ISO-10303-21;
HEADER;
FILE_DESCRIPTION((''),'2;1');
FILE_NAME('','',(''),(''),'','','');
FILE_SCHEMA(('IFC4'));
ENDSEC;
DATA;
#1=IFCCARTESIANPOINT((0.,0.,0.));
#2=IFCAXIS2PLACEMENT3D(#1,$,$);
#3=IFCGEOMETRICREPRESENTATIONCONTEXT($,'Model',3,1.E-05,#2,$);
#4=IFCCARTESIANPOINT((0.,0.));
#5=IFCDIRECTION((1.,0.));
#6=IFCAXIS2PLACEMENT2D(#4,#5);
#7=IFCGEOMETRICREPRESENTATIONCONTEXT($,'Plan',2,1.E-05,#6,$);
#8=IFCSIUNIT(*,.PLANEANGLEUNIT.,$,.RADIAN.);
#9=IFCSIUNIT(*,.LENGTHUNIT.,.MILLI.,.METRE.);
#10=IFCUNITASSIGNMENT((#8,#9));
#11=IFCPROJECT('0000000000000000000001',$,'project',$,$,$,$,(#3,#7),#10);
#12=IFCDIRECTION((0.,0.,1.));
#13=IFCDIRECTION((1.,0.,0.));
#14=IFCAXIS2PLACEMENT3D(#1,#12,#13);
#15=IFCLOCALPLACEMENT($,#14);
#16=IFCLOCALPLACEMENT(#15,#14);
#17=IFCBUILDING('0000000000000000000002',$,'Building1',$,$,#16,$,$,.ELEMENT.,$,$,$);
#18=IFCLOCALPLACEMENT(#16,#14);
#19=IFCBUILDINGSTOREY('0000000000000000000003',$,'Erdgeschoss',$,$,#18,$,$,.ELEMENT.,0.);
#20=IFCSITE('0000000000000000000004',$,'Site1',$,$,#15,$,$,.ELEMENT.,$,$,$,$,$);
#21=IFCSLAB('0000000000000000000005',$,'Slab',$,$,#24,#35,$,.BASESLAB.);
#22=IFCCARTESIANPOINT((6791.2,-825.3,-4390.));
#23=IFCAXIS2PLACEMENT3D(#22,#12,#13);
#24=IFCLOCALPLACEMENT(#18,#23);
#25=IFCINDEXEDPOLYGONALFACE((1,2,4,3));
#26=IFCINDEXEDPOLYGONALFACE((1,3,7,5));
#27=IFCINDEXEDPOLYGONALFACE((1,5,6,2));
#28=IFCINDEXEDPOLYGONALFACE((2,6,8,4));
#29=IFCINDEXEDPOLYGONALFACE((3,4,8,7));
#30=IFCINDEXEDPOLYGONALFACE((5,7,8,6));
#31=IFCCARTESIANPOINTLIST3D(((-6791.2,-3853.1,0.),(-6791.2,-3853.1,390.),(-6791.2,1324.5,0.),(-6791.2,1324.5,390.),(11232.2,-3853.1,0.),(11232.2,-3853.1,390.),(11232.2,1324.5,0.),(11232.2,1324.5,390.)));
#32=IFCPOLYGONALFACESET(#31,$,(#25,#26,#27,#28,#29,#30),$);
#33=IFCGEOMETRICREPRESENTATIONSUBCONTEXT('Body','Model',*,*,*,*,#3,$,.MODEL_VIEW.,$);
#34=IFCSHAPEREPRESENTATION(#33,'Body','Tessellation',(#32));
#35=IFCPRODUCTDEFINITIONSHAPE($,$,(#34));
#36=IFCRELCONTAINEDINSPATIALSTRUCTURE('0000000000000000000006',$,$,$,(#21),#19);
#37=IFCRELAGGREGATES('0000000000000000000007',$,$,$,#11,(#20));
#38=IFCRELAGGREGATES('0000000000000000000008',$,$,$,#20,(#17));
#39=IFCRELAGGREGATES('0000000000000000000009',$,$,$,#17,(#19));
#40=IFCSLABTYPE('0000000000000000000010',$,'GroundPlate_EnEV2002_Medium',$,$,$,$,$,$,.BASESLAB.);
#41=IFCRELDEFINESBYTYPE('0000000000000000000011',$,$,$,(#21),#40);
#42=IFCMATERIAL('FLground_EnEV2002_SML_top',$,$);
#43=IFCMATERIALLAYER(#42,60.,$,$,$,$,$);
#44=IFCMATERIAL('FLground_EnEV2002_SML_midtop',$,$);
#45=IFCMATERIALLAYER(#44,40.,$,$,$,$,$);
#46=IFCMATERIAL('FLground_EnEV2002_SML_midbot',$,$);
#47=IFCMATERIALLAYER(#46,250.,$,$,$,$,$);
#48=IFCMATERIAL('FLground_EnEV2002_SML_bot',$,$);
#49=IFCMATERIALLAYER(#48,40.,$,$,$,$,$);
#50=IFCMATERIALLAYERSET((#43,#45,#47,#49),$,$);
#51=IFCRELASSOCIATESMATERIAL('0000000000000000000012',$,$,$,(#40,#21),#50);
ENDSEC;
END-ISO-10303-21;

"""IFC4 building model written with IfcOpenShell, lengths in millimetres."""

from ifc_helpers import new_model, si_unit, frame, origin, origin_with_axes, origin_2d_with_axis, place, context, subcontext, project, spatial, line, indexed_curve, outline, extrude, material, layer, layer_set, layer_usage, type_object, element, save


model = new_model("IFC4")

# Units and contexts
model_context = context("Model", 3, precision=1e-05, world=origin())
plan_context = context("Plan", 2, precision=1e-05, world=origin_2d_with_axis())
body_context = subcontext(model_context, "Body", "Model", "MODEL_VIEW")
ifc_project = project(units=[si_unit("PLANEANGLEUNIT", "RADIAN"), si_unit("LENGTHUNIT", "METRE", prefix="MILLI")], contexts=[model_context, plan_context])

# Site, building, storey
site_placement = place(None, origin_with_axes())
site = spatial("IfcSite", under=ifc_project, at=site_placement, Name="Site1", CompositionType="ELEMENT")
building_placement = place(site_placement, origin_with_axes())
building = spatial("IfcBuilding", under=site, at=building_placement, Name="Building1", CompositionType="ELEMENT")
storey_placement = place(building_placement, origin_with_axes())
storey = spatial("IfcBuildingStorey", under=building, at=storey_placement, Name="Erdgeschoss", CompositionType="ELEMENT", Elevation=0.0)

# Slab
ifc_material_1 = material(Name="FLground_EnEV2002_SML_top")
ifc_layer_1 = layer(ifc_material_1, 60.0)
ifc_material_2 = material(Name="FLground_EnEV2002_SML_midtop")
ifc_layer_2 = layer(ifc_material_2, 40.0)
ifc_material_3 = material(Name="FLground_EnEV2002_SML_midbot")
ifc_layer_3 = layer(ifc_material_3, 250.0)
ifc_material_4 = material(Name="FLground_EnEV2002_SML_bot")
ifc_layer_4 = layer(ifc_material_4, 40.0)
ifc_layer_set_1 = layer_set([ifc_layer_1, ifc_layer_2, ifc_layer_3, ifc_layer_4])
ifc_layer_usage_1 = layer_usage(ifc_layer_set_1, "AXIS3", "POSITIVE", 0.0)
slab_type = type_object("IfcSlabType", Name="GroundPlate_EnEV2002_Medium", PredefinedType="BASESLAB", material=ifc_layer_set_1)
slab_placement = place(storey_placement, frame((6791.2, -825.3, -4390.0), z_axis=(0.0, 0.0, 1.0), x_axis=(1.0, 0.0, 0.0)))
element("IfcSlab", 1, at=slab_placement, inside=storey, type_object=slab_type, material=ifc_layer_usage_1, Name="Slab", PredefinedType="BASESLAB", context=body_context, shape_type="SweptSolid", body=[
    extrude(outline(indexed_curve([(-6791.2, -3853.1), (11232.2, -3853.1), (11232.2, 1324.5), (-6791.2, 1324.5)], segments=[line(4, 1), line(1, 2), line(2, 3), line(3, 4)], self_intersect=False)), None, (0.0, 0.0, 1.0), 390.0),
])

save(model, "model.ifc")
